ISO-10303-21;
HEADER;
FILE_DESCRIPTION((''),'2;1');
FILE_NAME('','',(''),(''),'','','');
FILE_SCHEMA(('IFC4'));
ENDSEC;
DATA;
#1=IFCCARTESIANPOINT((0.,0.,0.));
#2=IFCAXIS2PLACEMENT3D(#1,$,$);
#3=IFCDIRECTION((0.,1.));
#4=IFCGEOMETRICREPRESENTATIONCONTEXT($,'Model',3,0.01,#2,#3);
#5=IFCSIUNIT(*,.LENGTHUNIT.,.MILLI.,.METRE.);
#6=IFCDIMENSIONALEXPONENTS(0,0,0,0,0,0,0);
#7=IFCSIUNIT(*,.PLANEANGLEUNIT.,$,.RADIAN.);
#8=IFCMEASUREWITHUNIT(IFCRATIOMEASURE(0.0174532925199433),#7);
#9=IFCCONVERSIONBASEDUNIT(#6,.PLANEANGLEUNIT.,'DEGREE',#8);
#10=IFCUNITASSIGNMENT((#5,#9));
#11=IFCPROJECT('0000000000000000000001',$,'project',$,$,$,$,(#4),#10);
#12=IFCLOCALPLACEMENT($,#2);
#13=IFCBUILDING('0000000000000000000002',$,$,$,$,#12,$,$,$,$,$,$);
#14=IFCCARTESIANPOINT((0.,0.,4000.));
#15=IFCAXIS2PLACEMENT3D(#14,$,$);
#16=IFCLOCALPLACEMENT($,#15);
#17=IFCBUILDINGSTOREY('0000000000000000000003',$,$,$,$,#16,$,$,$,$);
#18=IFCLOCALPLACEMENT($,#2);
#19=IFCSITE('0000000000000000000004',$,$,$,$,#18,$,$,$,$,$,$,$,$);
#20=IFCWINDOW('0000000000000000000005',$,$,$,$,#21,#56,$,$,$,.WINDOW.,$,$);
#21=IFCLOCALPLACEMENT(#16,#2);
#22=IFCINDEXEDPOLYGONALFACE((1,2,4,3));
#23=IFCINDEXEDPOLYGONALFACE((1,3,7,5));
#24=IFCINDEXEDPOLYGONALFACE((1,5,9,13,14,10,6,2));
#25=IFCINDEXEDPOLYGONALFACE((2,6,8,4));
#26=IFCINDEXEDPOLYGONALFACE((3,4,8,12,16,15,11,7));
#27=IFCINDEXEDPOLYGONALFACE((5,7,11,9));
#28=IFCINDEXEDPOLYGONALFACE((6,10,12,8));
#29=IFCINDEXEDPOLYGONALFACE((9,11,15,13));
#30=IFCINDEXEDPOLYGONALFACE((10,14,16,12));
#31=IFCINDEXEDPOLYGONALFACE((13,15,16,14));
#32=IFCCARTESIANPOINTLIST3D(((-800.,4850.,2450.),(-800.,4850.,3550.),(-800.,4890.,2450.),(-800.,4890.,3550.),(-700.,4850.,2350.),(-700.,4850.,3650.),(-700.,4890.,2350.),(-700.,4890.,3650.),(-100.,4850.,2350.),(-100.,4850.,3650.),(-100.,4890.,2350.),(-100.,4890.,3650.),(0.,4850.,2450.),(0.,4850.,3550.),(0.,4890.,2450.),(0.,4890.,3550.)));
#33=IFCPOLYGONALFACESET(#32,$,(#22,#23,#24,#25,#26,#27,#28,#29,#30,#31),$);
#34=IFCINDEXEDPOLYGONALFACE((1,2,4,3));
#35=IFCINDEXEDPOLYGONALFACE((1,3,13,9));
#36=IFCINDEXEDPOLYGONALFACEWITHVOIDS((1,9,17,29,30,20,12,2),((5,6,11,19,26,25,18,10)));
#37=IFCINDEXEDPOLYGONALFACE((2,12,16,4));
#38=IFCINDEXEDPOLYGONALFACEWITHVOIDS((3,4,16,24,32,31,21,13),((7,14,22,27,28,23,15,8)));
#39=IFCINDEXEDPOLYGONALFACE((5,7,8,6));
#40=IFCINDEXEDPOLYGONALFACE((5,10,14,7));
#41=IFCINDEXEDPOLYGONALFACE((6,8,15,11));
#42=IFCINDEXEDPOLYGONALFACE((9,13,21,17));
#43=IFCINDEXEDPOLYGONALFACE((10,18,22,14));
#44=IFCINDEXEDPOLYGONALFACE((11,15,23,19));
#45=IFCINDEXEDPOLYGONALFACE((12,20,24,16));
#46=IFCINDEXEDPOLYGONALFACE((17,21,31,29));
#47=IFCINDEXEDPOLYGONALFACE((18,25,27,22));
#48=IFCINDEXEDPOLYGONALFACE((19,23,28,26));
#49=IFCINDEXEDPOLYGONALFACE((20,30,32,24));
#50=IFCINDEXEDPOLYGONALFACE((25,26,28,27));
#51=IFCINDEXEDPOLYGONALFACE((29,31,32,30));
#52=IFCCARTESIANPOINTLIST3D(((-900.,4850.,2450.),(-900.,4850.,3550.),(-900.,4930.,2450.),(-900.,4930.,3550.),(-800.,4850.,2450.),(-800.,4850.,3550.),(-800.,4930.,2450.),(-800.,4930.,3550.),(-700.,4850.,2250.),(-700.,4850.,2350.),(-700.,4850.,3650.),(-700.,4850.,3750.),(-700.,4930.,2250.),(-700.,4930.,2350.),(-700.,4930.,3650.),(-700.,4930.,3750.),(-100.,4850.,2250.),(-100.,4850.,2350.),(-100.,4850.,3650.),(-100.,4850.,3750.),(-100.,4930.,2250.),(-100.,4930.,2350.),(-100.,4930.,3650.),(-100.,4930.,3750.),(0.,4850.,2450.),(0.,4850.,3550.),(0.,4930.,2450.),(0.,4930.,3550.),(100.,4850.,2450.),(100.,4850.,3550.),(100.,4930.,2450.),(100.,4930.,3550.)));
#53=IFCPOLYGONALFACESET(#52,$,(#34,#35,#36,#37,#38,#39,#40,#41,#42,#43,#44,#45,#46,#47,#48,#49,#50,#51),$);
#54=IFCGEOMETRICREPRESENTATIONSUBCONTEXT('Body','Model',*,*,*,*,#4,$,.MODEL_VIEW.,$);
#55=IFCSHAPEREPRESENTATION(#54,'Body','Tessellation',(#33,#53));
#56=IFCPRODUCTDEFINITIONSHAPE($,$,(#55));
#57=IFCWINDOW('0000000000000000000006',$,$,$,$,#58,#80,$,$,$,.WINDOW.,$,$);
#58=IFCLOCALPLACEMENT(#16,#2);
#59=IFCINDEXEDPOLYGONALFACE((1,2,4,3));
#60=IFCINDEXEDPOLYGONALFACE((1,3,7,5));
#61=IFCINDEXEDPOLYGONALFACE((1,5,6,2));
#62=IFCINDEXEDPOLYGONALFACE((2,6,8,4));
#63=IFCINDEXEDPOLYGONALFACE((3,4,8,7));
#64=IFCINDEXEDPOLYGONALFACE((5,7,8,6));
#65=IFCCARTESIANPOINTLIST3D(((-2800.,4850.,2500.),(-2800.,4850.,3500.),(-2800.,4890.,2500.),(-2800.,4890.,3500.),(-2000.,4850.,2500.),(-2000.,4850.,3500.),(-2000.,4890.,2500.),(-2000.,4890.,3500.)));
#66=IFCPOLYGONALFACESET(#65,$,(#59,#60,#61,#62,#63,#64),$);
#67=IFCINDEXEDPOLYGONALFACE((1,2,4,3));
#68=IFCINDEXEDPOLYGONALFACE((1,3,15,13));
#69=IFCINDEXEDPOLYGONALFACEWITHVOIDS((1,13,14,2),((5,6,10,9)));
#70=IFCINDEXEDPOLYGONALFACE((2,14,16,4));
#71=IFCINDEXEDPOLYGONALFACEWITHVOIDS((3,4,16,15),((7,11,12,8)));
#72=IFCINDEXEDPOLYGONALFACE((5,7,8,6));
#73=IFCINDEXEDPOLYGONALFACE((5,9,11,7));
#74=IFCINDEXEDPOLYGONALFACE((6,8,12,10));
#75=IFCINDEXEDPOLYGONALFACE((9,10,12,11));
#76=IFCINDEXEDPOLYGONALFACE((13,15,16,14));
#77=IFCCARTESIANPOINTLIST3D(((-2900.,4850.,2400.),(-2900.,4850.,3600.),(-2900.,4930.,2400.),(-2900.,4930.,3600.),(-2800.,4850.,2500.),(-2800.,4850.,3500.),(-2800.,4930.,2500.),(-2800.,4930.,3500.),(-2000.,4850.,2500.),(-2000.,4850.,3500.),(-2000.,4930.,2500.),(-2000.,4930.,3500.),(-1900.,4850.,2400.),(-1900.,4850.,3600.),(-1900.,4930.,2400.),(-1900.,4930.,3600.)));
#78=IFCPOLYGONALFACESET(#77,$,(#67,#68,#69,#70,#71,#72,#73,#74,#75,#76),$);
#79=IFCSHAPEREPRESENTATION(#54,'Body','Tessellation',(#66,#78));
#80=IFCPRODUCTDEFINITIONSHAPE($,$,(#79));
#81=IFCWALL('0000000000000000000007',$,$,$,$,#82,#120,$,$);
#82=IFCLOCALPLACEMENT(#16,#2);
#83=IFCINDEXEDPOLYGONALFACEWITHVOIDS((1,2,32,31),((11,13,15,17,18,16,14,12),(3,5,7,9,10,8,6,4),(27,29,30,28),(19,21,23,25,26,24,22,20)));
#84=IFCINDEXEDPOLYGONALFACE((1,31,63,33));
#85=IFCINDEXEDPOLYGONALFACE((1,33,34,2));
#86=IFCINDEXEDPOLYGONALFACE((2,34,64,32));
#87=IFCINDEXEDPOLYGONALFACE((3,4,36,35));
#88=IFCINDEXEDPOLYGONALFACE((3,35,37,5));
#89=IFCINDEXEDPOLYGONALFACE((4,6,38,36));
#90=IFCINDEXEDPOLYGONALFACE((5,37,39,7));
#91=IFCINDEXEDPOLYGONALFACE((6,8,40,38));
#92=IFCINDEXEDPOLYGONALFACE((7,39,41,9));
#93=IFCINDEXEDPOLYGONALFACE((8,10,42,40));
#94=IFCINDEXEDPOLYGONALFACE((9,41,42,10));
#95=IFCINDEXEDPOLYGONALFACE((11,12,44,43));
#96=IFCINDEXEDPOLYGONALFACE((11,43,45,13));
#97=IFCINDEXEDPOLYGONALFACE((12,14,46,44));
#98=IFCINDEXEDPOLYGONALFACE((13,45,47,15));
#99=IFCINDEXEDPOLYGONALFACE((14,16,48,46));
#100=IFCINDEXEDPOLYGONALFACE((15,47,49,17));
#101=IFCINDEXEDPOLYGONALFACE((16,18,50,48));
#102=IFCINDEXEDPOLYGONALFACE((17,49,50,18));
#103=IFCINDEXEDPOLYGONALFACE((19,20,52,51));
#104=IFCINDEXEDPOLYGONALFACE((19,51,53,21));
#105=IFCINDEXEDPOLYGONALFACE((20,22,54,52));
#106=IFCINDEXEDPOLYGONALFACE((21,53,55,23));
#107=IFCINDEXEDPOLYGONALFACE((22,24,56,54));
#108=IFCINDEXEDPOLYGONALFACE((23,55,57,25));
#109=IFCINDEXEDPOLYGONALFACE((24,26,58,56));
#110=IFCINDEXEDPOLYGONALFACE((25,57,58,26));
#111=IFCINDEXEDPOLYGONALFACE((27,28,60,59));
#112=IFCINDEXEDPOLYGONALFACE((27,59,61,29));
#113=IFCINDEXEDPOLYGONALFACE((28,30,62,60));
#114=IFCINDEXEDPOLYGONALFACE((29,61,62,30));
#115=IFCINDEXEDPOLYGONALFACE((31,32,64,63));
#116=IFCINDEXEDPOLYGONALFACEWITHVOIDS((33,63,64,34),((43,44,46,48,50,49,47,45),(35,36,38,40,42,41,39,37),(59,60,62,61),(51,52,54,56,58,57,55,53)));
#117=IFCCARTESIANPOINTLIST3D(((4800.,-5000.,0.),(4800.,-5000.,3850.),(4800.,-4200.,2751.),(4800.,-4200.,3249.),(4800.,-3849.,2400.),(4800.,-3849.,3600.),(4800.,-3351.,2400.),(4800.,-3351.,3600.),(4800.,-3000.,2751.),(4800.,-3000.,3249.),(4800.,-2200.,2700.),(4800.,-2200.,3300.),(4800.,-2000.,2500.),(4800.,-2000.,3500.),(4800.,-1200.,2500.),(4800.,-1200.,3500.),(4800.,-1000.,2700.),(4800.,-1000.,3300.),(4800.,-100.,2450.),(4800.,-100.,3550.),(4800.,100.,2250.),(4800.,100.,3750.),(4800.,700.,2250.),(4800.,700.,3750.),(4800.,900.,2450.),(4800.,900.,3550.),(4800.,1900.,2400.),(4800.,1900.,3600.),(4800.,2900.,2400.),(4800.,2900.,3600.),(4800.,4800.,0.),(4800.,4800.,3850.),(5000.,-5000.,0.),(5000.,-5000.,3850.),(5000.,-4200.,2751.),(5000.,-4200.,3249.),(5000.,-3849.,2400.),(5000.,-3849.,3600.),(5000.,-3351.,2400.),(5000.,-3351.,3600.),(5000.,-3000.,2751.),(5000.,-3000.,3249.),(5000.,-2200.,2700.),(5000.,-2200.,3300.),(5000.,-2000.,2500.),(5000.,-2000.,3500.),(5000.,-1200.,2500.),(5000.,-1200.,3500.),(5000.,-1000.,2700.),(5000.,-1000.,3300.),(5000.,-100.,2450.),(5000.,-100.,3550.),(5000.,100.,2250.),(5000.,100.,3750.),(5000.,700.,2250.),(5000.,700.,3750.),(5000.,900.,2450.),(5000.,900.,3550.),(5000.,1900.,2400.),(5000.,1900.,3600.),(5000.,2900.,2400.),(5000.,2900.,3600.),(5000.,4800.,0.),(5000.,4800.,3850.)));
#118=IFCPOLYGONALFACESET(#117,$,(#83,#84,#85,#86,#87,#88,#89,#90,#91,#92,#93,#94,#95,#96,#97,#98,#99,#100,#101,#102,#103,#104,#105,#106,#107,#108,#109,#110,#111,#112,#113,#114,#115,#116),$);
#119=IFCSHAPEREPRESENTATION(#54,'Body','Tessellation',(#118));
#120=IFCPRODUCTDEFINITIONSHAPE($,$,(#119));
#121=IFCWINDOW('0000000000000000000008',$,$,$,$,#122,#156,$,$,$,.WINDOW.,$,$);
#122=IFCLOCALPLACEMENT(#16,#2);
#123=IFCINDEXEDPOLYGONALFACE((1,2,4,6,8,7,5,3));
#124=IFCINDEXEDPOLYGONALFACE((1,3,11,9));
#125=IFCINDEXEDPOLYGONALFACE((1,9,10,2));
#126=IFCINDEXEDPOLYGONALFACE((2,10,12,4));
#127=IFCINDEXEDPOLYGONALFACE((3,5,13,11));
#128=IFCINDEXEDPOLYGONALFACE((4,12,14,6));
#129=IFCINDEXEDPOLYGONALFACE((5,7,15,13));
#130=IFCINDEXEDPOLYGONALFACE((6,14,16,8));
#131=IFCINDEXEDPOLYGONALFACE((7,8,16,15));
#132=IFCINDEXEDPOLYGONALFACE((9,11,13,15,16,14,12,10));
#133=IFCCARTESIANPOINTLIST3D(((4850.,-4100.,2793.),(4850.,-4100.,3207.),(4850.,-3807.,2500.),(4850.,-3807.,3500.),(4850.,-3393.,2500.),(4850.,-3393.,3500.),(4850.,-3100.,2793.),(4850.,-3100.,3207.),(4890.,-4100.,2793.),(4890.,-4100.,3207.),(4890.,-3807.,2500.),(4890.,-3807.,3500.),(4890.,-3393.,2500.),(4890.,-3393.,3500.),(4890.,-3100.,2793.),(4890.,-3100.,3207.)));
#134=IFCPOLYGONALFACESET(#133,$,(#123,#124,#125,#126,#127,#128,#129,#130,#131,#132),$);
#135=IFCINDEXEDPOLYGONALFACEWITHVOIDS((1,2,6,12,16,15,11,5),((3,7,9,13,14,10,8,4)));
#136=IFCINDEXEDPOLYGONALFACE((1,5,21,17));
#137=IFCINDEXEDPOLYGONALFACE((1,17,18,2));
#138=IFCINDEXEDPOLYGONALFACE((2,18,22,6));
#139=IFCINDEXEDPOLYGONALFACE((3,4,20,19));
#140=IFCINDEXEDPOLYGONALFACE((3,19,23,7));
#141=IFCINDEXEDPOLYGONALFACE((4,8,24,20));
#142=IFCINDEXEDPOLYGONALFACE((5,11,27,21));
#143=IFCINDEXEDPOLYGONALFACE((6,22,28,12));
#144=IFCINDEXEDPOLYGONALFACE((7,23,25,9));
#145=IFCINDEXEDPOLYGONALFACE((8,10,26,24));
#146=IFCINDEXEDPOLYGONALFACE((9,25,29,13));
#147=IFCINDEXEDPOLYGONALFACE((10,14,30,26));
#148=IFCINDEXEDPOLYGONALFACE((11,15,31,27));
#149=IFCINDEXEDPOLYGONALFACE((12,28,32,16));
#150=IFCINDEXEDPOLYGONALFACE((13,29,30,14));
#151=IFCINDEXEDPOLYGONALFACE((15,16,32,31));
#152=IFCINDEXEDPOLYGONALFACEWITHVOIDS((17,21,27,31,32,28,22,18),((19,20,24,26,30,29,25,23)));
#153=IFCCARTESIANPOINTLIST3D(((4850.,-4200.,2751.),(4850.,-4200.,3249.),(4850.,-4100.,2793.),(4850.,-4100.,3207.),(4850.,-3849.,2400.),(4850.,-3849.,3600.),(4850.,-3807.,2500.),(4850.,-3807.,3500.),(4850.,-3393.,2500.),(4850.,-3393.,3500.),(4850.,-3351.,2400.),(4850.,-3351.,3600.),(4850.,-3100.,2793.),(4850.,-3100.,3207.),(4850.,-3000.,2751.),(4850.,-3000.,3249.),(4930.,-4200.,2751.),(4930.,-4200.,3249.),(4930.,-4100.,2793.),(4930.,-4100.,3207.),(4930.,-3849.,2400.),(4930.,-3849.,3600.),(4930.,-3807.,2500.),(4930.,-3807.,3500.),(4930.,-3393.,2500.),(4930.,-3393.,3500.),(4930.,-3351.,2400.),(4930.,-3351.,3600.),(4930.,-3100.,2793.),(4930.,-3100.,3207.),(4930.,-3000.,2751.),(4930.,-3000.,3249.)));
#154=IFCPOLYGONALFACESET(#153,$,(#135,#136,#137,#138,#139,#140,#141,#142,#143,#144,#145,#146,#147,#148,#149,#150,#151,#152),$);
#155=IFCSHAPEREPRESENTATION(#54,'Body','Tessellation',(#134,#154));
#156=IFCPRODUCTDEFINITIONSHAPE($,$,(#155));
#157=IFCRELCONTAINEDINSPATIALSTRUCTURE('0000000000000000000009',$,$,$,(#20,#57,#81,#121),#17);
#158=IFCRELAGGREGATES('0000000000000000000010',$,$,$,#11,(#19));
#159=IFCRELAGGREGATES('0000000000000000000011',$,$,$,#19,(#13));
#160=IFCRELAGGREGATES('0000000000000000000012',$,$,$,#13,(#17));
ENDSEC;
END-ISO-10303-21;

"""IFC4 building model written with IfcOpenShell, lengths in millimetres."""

from ifc_helpers import new_model, entity, si_unit, converted_unit, direction, frame, origin, origin_2d, place, context, subcontext, project, spatial, polyline, rectangle, outline, extrude, element, save


model = new_model("IFC4")

# Units and contexts
model_context = context("Model", 3, precision=0.01, world=origin(), true_north=direction((0.0, 1.0)))
body_context = subcontext(model_context, "Body", "Model", "MODEL_VIEW")
ifc_project = project(units=[si_unit("LENGTHUNIT", "METRE", prefix="MILLI"), converted_unit("PLANEANGLEUNIT", "DEGREE", entity("IfcRatioMeasure", 0.0174532925199433), si_unit("PLANEANGLEUNIT", "RADIAN"), dimensions=[0, 0, 0, 0, 0, 0, 0])], contexts=[model_context])

# Site, building, storey
site_placement = place(None, origin())
site = spatial("IfcSite", under=ifc_project, at=site_placement)
building_placement = place(None, origin())
building = spatial("IfcBuilding", under=site, at=building_placement)
storey_placement = place(None, frame((0.0, 0.0, 4000.0)))
storey = spatial("IfcBuildingStorey", under=building, at=storey_placement)

# Shared definitions
wall_1_placement = place(storey_placement, frame((100.0, 4900.0, 0.0), z_axis=(0.0, 0.0, 1.0), x_axis=(-1.0, 0.0, 0.0)))
window_1_placement = place(wall_1_placement, frame((500.0, 50.0, 3000.0)))
window_2_placement = place(wall_1_placement, frame((2500.0, 50.0, 3000.0)))

# Windows
cartesian_point_1 = entity("IfcCartesianPoint", [-500.0, -207.0])
shared_polyline_1 = entity("IfcPolyline", [cartesian_point_1, entity("IfcCartesianPoint", [-500.0, 207.0]), entity("IfcCartesianPoint", [-207.0, 500.0]), entity("IfcCartesianPoint", [207.0, 500.0]), entity("IfcCartesianPoint", [500.0, 207.0]), entity("IfcCartesianPoint", [500.0, -207.0]), entity("IfcCartesianPoint", [207.0, -500.0]), entity("IfcCartesianPoint", [-207.0, -500.0]), cartesian_point_1])
cartesian_point_2 = entity("IfcCartesianPoint", [-400.0, -550.0])
shared_polyline_2 = entity("IfcPolyline", [cartesian_point_2, entity("IfcCartesianPoint", [-400.0, 550.0]), entity("IfcCartesianPoint", [-300.0, 650.0]), entity("IfcCartesianPoint", [300.0, 650.0]), entity("IfcCartesianPoint", [400.0, 550.0]), entity("IfcCartesianPoint", [400.0, -550.0]), entity("IfcCartesianPoint", [300.0, -650.0]), entity("IfcCartesianPoint", [-300.0, -650.0]), cartesian_point_2])
cartesian_point_3 = entity("IfcCartesianPoint", [-500.0, -550.0])
element("IfcWindow", 1, at=window_1_placement, inside=storey, PredefinedType="WINDOW", context=body_context, shape_type="SweptSolid", body=[
    entity("IfcExtrudedAreaSolid", entity("IfcArbitraryClosedProfileDef", "AREA", None, shared_polyline_2), entity("IfcAxis2Placement3D", entity("IfcCartesianPoint", [0.0, 0.0, 0.0]), entity("IfcDirection", [0.0, -1.0, 0.0]), entity("IfcDirection", [1.0, 0.0, 0.0])), entity("IfcDirection", [0.0, 0.0, 1.0]), 40.0),
    entity("IfcExtrudedAreaSolid", entity("IfcArbitraryProfileDefWithVoids", "AREA", None, entity("IfcPolyline", [cartesian_point_3, entity("IfcCartesianPoint", [-500.0, 550.0]), entity("IfcCartesianPoint", [-300.0, 750.0]), entity("IfcCartesianPoint", [300.0, 750.0]), entity("IfcCartesianPoint", [500.0, 550.0]), entity("IfcCartesianPoint", [500.0, -550.0]), entity("IfcCartesianPoint", [300.0, -750.0]), entity("IfcCartesianPoint", [-300.0, -750.0]), cartesian_point_3]), [shared_polyline_2]), entity("IfcAxis2Placement3D", entity("IfcCartesianPoint", [0.0, 0.0, 0.0]), entity("IfcDirection", [0.0, -1.0, 0.0]), entity("IfcDirection", [1.0, 0.0, 0.0])), entity("IfcDirection", [0.0, 0.0, 1.0]), 80.0),
])
cartesian_point_4 = entity("IfcCartesianPoint", [-400.0, -500.0])
shared_polyline_3 = entity("IfcPolyline", [cartesian_point_4, entity("IfcCartesianPoint", [-400.0, 500.0]), entity("IfcCartesianPoint", [-400.0, 500.0]), entity("IfcCartesianPoint", [400.0, 500.0]), entity("IfcCartesianPoint", [400.0, 500.0]), entity("IfcCartesianPoint", [400.0, -500.0]), entity("IfcCartesianPoint", [400.0, -500.0]), entity("IfcCartesianPoint", [-400.0, -500.0]), cartesian_point_4])
cartesian_point_5 = entity("IfcCartesianPoint", [-500.0, -600.0])
element("IfcWindow", 2, at=window_2_placement, inside=storey, PredefinedType="WINDOW", context=body_context, shape_type="SweptSolid", body=[
    entity("IfcExtrudedAreaSolid", entity("IfcArbitraryClosedProfileDef", "AREA", None, shared_polyline_3), entity("IfcAxis2Placement3D", entity("IfcCartesianPoint", [0.0, 0.0, 0.0]), entity("IfcDirection", [0.0, -1.0, 0.0]), entity("IfcDirection", [1.0, 0.0, 0.0])), entity("IfcDirection", [0.0, 0.0, 1.0]), 40.0),
    entity("IfcExtrudedAreaSolid", entity("IfcArbitraryProfileDefWithVoids", "AREA", None, entity("IfcPolyline", [cartesian_point_5, entity("IfcCartesianPoint", [-500.0, 600.0]), entity("IfcCartesianPoint", [-500.0, 600.0]), entity("IfcCartesianPoint", [500.0, 600.0]), entity("IfcCartesianPoint", [500.0, 600.0]), entity("IfcCartesianPoint", [500.0, -600.0]), entity("IfcCartesianPoint", [500.0, -600.0]), entity("IfcCartesianPoint", [-500.0, -600.0]), cartesian_point_5]), [shared_polyline_3]), entity("IfcAxis2Placement3D", entity("IfcCartesianPoint", [0.0, 0.0, 0.0]), entity("IfcDirection", [0.0, -1.0, 0.0]), entity("IfcDirection", [1.0, 0.0, 0.0])), entity("IfcDirection", [0.0, 0.0, 1.0]), 80.0),
])

# Wall, openings
wall_2_placement = place(storey_placement, frame((4900.0, -100.0, 0.0), z_axis=(0.0, 0.0, 1.0), x_axis=(0.0, 1.0, 0.0)))
wall_2 = element("IfcWall", 3, at=wall_2_placement, inside=storey, context=body_context, shape_type="SweptSolid", body=[
    extrude(rectangle(XDim=9800.0, YDim=200.0, at=origin_2d()), origin(), (0.0, 0.0, 1.0), 3850.0),
])
window_3_placement = place(wall_2_placement, frame((-3500.0, 50.0, 3000.0)))
opening_1_placement = place(window_3_placement, frame((0.0, 50.0, 0.0)))
element("IfcOpeningElement", 4, at=opening_1_placement, cuts=wall_2, context=body_context, shape_type="SweptSolid", body=[
    extrude(outline(polyline([(-600.0, -249.0), (-600.0, 249.0), (-249.0, 600.0), (249.0, 600.0), (600.0, 249.0), (600.0, -249.0), (249.0, -600.0), (-249.0, -600.0), (-600.0, -249.0)])), frame((0.0, 0.0, 0.0), z_axis=(0.0, -1.0, 0.0), x_axis=(1.0, 0.0, 0.0)), (0.0, 0.0, 1.0), 200.0),
])
window_4_placement = place(wall_2_placement, frame((-1500.0, 50.0, 3000.0)))
opening_2_placement = place(window_4_placement, frame((0.0, 50.0, 0.0)))
element("IfcOpeningElement", 5, at=opening_2_placement, cuts=wall_2, context=body_context, shape_type="SweptSolid", body=[
    extrude(outline(polyline([(-600.0, -300.0), (-600.0, 300.0), (-400.0, 500.0), (400.0, 500.0), (600.0, 300.0), (600.0, -300.0), (400.0, -500.0), (-400.0, -500.0), (-600.0, -300.0)])), frame((0.0, 0.0, 0.0), z_axis=(0.0, -1.0, 0.0), x_axis=(1.0, 0.0, 0.0)), (0.0, 0.0, 1.0), 200.0),
])
window_5_placement = place(wall_2_placement, frame((500.0, 50.0, 3000.0)))
opening_3_placement = place(window_5_placement, frame((0.0, 50.0, 0.0)))
element("IfcOpeningElement", 6, at=opening_3_placement, cuts=wall_2, context=body_context, shape_type="SweptSolid", body=[
    extrude(outline(polyline([(-500.0, -550.0), (-500.0, 550.0), (-300.0, 750.0), (300.0, 750.0), (500.0, 550.0), (500.0, -550.0), (300.0, -750.0), (-300.0, -750.0), (-500.0, -550.0)])), frame((0.0, 0.0, 0.0), z_axis=(0.0, -1.0, 0.0), x_axis=(1.0, 0.0, 0.0)), (0.0, 0.0, 1.0), 200.0),
])
window_6_placement = place(wall_2_placement, frame((2500.0, 50.0, 3000.0)))
opening_4_placement = place(window_6_placement, frame((0.0, 50.0, 0.0)))
element("IfcOpeningElement", 7, at=opening_4_placement, cuts=wall_2, context=body_context, shape_type="SweptSolid", body=[
    extrude(outline(polyline([(-500.0, -600.0), (-500.0, 600.0), (-500.0, 600.0), (500.0, 600.0), (500.0, 600.0), (500.0, -600.0), (500.0, -600.0), (-500.0, -600.0), (-500.0, -600.0)])), frame((0.0, 0.0, 0.0), z_axis=(0.0, -1.0, 0.0), x_axis=(1.0, 0.0, 0.0)), (0.0, 0.0, 1.0), 200.0),
])

# Window
cartesian_point_6 = entity("IfcCartesianPoint", [-600.0, -249.0])
element("IfcWindow", 8, at=window_3_placement, inside=storey, PredefinedType="WINDOW", context=body_context, shape_type="SweptSolid", body=[
    entity("IfcExtrudedAreaSolid", entity("IfcArbitraryClosedProfileDef", "AREA", None, shared_polyline_1), entity("IfcAxis2Placement3D", entity("IfcCartesianPoint", [0.0, 0.0, 0.0]), entity("IfcDirection", [0.0, -1.0, 0.0]), entity("IfcDirection", [1.0, 0.0, 0.0])), entity("IfcDirection", [0.0, 0.0, 1.0]), 40.0),
    entity("IfcExtrudedAreaSolid", entity("IfcArbitraryProfileDefWithVoids", "AREA", None, entity("IfcPolyline", [cartesian_point_6, entity("IfcCartesianPoint", [-600.0, 249.0]), entity("IfcCartesianPoint", [-249.0, 600.0]), entity("IfcCartesianPoint", [249.0, 600.0]), entity("IfcCartesianPoint", [600.0, 249.0]), entity("IfcCartesianPoint", [600.0, -249.0]), entity("IfcCartesianPoint", [249.0, -600.0]), entity("IfcCartesianPoint", [-249.0, -600.0]), cartesian_point_6]), [shared_polyline_1]), entity("IfcAxis2Placement3D", entity("IfcCartesianPoint", [0.0, 0.0, 0.0]), entity("IfcDirection", [0.0, -1.0, 0.0]), entity("IfcDirection", [1.0, 0.0, 0.0])), entity("IfcDirection", [0.0, 0.0, 1.0]), 80.0),
])

save(model, "model.ifc")
